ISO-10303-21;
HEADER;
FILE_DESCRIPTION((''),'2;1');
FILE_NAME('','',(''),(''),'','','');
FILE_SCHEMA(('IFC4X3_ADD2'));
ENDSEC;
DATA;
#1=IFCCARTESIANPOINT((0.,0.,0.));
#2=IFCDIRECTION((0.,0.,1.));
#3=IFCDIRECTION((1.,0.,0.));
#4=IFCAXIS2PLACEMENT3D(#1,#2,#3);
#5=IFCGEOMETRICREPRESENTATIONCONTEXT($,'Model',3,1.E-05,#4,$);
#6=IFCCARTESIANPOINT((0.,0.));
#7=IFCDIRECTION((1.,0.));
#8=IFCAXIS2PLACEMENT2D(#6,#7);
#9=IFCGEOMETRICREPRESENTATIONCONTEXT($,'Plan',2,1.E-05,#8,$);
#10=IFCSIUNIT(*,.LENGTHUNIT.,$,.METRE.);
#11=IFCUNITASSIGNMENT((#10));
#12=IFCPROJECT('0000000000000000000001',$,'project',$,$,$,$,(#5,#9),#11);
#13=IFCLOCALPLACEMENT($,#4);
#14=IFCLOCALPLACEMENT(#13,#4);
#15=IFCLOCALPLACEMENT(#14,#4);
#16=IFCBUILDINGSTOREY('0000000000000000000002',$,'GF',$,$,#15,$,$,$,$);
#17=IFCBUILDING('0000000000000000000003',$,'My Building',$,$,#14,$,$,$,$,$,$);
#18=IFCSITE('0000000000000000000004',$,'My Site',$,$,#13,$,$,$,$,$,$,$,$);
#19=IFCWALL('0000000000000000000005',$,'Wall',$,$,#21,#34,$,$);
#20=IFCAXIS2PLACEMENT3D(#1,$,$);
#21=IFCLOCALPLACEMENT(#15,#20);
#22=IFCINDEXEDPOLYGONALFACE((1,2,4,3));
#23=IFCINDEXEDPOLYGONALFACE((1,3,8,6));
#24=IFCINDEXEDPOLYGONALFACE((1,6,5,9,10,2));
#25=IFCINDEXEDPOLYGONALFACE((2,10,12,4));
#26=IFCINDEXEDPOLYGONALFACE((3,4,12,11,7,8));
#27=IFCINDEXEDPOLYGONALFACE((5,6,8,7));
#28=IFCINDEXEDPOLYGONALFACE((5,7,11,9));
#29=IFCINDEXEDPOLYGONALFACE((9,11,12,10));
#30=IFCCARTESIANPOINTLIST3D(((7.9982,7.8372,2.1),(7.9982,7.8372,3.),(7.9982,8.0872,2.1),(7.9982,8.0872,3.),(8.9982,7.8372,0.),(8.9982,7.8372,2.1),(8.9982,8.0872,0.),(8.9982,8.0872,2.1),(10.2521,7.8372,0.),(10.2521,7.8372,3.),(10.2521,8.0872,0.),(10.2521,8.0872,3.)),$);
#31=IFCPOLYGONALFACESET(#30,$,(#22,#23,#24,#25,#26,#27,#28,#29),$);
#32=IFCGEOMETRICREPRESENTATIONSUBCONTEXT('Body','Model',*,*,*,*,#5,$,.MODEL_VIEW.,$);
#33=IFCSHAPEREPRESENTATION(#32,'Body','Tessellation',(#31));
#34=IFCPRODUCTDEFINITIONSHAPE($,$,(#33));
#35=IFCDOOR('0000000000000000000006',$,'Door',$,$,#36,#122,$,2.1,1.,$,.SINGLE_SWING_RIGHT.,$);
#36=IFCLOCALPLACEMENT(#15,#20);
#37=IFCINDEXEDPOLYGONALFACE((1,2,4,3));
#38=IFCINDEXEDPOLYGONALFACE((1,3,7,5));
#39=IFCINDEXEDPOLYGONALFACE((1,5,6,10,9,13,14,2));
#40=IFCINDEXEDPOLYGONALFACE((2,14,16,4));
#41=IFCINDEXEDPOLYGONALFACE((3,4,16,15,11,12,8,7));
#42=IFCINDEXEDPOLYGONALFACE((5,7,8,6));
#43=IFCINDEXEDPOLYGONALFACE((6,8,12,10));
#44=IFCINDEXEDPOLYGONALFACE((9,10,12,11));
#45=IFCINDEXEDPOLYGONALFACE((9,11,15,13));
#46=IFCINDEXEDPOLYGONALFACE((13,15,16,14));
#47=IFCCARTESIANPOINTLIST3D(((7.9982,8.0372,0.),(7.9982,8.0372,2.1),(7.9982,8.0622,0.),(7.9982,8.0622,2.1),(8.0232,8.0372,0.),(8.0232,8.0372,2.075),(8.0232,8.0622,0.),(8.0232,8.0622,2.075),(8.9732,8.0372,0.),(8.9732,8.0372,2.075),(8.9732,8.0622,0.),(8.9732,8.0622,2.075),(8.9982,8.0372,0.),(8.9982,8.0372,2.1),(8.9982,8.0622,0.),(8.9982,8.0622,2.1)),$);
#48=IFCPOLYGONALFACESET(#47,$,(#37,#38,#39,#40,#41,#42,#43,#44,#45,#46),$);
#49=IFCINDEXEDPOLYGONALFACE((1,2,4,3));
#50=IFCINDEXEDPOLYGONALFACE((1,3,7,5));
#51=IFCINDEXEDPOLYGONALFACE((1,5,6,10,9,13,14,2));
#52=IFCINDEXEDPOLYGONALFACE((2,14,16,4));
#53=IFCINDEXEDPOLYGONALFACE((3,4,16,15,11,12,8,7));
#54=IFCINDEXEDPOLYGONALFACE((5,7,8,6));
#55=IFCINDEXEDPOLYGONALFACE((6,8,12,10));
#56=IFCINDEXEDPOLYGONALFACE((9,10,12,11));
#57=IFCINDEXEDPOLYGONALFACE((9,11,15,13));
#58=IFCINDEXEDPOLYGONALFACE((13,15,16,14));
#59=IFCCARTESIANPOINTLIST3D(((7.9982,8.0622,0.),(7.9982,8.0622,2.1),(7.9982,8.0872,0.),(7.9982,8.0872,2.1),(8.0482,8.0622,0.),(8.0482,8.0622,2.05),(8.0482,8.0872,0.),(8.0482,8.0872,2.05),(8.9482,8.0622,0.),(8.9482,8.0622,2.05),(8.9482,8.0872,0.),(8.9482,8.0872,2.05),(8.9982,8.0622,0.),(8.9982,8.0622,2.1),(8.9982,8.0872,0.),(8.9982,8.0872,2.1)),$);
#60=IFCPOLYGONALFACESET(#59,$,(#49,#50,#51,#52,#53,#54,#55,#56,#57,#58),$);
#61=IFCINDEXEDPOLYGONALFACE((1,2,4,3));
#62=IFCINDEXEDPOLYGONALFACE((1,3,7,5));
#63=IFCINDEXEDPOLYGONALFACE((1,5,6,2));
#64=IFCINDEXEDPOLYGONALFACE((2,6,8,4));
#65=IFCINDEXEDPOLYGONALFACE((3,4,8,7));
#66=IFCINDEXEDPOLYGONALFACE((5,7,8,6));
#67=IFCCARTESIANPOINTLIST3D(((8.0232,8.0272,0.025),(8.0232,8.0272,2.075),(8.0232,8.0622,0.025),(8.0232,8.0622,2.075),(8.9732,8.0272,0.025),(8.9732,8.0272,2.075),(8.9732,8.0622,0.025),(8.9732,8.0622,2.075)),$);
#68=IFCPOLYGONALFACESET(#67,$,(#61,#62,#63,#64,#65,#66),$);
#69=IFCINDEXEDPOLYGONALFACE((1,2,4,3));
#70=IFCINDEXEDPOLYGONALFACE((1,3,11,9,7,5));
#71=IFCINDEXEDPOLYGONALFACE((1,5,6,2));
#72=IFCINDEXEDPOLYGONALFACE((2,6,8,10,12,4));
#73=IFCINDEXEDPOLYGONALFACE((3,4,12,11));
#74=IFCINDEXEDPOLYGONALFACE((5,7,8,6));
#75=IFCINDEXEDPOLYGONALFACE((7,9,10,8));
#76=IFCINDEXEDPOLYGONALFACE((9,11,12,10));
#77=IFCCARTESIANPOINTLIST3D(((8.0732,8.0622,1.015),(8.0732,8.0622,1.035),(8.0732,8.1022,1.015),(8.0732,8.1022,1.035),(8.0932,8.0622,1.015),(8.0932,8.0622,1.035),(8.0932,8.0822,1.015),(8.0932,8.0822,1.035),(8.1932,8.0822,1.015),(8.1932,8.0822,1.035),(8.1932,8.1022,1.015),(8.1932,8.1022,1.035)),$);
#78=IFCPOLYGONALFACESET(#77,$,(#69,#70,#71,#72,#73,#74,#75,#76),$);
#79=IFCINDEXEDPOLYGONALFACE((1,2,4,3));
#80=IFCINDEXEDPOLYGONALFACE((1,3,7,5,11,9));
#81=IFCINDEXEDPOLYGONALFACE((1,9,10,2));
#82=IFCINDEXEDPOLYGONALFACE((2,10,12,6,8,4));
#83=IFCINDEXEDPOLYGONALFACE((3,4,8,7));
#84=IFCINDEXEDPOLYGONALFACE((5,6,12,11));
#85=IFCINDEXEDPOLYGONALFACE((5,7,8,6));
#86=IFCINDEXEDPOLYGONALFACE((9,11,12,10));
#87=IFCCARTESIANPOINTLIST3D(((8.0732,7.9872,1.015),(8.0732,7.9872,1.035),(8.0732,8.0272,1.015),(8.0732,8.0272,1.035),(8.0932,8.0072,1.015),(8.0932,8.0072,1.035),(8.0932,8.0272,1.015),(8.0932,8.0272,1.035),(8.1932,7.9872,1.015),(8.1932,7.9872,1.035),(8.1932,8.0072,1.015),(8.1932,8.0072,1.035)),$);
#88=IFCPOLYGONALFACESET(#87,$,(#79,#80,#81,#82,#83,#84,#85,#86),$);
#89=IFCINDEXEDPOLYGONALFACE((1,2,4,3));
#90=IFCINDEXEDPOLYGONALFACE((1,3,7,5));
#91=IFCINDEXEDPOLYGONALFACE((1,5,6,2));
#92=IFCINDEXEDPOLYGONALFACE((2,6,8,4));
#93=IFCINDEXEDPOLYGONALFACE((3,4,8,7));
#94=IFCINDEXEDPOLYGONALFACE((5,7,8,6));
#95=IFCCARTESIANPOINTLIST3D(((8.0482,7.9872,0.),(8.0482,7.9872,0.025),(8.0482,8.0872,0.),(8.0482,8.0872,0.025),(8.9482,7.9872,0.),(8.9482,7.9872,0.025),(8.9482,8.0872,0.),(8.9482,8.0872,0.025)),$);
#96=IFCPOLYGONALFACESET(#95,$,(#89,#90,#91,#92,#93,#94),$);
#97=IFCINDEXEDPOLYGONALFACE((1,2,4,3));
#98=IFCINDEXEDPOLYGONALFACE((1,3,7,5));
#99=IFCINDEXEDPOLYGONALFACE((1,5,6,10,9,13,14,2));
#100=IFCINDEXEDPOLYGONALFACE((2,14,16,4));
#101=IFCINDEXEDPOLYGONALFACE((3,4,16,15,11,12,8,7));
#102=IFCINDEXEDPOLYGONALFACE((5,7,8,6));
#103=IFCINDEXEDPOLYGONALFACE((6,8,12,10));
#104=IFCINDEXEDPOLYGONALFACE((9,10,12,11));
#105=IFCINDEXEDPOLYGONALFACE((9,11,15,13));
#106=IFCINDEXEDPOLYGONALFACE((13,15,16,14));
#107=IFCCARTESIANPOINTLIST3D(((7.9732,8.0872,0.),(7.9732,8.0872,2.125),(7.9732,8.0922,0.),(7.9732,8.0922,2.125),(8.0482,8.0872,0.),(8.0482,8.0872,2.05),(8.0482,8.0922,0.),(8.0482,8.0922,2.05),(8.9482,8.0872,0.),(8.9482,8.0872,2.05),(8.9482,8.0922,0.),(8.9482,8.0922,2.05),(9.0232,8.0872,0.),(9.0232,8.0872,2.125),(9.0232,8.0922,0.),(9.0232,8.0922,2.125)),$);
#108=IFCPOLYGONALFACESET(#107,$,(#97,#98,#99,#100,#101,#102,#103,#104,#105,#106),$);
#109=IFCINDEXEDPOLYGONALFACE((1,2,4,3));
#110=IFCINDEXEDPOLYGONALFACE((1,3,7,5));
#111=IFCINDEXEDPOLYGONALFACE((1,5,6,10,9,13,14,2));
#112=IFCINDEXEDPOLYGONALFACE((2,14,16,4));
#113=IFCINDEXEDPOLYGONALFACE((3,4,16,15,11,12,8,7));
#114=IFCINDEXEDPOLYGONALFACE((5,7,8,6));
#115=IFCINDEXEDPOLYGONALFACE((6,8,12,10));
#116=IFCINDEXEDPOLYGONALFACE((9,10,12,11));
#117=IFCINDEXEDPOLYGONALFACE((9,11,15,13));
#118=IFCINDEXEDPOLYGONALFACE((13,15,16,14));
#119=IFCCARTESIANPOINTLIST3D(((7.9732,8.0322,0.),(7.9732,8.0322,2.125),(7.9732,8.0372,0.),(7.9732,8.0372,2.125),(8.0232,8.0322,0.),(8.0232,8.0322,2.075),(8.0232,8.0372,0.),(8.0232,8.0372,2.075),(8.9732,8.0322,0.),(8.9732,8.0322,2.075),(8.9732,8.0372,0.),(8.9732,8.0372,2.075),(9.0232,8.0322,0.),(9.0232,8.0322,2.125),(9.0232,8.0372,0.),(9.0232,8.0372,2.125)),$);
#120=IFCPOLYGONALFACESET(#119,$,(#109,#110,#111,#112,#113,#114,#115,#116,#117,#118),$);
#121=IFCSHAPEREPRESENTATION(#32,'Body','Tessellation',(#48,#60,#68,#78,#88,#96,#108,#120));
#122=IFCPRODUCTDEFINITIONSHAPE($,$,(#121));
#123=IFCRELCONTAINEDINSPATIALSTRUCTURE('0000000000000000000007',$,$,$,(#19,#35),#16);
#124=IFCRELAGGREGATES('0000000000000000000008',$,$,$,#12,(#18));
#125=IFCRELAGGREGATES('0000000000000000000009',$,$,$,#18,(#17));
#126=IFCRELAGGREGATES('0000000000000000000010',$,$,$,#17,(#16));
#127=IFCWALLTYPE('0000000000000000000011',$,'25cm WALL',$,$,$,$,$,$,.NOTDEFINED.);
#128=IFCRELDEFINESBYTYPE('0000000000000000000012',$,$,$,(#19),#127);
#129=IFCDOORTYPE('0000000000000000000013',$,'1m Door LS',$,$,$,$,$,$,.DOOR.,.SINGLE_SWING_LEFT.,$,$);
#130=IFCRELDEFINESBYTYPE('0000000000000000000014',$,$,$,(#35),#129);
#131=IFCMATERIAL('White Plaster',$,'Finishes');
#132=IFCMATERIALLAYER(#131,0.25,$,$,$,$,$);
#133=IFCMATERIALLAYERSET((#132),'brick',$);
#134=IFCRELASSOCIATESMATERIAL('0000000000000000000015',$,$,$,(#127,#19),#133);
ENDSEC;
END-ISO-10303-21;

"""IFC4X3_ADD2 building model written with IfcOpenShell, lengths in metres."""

from ifc_helpers import new_model, entity, si_unit, frame, origin_with_axes, origin_2d_with_axis, place, context, subcontext, project, spatial, line, indexed_curve, outline, extrude, shape, source, transform, mapped, material, layer, layer_set, layer_usage, type_object, type_shapes, element, fill, save


model = new_model("IFC4X3_ADD2")

# Units and contexts
model_context = context("Model", 3, precision=1e-05, world=origin_with_axes())
plan_context = context("Plan", 2, precision=1e-05, world=origin_2d_with_axis())
body_context_1 = subcontext(model_context, "Body", "Model", "MODEL_VIEW")
body_context_2 = subcontext(plan_context, "Body", "Plan", "PLAN_VIEW")
ifc_project = project(units=[si_unit("LENGTHUNIT", "METRE")], contexts=[model_context, plan_context])

# Site, building, storey
site_placement = place(None, origin_with_axes())
site = spatial("IfcSite", under=ifc_project, at=site_placement, Name="My Site")
building_placement = place(site_placement, origin_with_axes())
building = spatial("IfcBuilding", under=site, at=building_placement, Name="My Building")
storey_placement = place(building_placement, origin_with_axes())
storey = spatial("IfcBuildingStorey", under=building, at=storey_placement, Name="GF")

# Shared definitions
ifc_material_1 = material(Name="White Plaster", Category="Finishes")

# Wall, opening, door
ifc_layer_1 = layer(ifc_material_1, 0.25)
ifc_layer_set_1 = layer_set([ifc_layer_1], Name="brick")
wall_type_1 = type_object("IfcWallType", Name="25cm WALL", PredefinedType="NOTDEFINED", material=ifc_layer_set_1)
shared_shape_1 = source(origin_with_axes(), body_context_1, "Body", "SweptSolid", [
    extrude(outline(indexed_curve([(0.0, 0.0), (1.0, 0.0), (1.0, 2.1), (0.0, 2.1)], segments=[line(1, 2, 3, 4, 1)])), frame((0.0, -0.6, 0.0), z_axis=(0.0, -1.0, 0.0), x_axis=(1.0, 0.0, 0.0)), (0.0, 0.0, -1.0), 1.2),
])
door_type_1 = type_object("IfcDoorType", Name="1m Door LS", OperationType="SINGLE_SWING_LEFT", PredefinedType="DOOR")
shared_shape_2 = source(origin_with_axes(), body_context_1, "Body", "SweptSolid", [
    extrude(outline(indexed_curve([(0.0, 0.0), (0.0, 2.1), (1.0, 2.1), (1.0, 0.0), (0.975, 0.0), (0.975, 2.075), (0.025, 2.075), (0.025, 0.0)], segments=[line(1, 2, 3, 4, 5, 6, 7, 8, 1)])), frame((0.0, 0.025, 0.0), z_axis=(0.0, -1.0, 0.0), x_axis=(1.0, 0.0, 0.0)), (0.0, 0.0, -1.0), 0.025),
    extrude(outline(indexed_curve([(0.0, 0.0), (0.0, 2.1), (1.0, 2.1), (1.0, 0.0), (0.95, 0.0), (0.95, 2.05), (0.05, 2.05), (0.05, 0.0)], segments=[line(1, 2, 3, 4, 5, 6, 7, 8, 1)])), frame((0.0, 0.0, 0.0), z_axis=(0.0, -1.0, 0.0), x_axis=(1.0, 0.0, 0.0)), (0.0, 0.0, -1.0), 0.025),
    extrude(outline(indexed_curve([(0.0, 0.0), (0.95, 0.0), (0.95, 0.035), (0.0, 0.035)], segments=[line(1, 2, 3, 4, 1)])), frame((0.025, 0.025, 0.025), z_axis=(0.0, 0.0, 1.0), x_axis=(1.0, 0.0, 0.0)), (0.0, 0.0, 1.0), 2.05),
    extrude(outline(indexed_curve([(0.0, 0.0), (0.0, -0.04), (-0.12, -0.04), (-0.12, -0.02), (-0.02, -0.02), (-0.02, 0.0)], segments=[line(1, 2, 3, 4, 5, 6, 1)])), frame((0.925, 0.025, 1.015), z_axis=(0.0, 0.0, 1.0), x_axis=(1.0, 0.0, 0.0)), (0.0, 0.0, 1.0), 0.02),
    extrude(outline(indexed_curve([(0.0, 0.0), (0.0, 0.04), (-0.12, 0.04), (-0.12, 0.02), (-0.02, 0.02), (-0.02, 0.0)], segments=[line(1, 2, 3, 4, 5, 6, 1)])), frame((0.925, 0.06, 1.015), z_axis=(0.0, 0.0, 1.0), x_axis=(1.0, 0.0, 0.0)), (0.0, 0.0, 1.0), 0.02),
    extrude(outline(indexed_curve([(0.0, 0.0), (0.9, 0.0), (0.9, 0.1), (0.0, 0.1)], segments=[line(1, 2, 3, 4, 1)])), frame((0.05, 0.0, 0.0), z_axis=(0.0, 0.0, 1.0), x_axis=(1.0, 0.0, 0.0)), (0.0, 0.0, 1.0), 0.025),
    extrude(outline(indexed_curve([(0.0, 0.0), (0.0, 2.125), (1.05, 2.125), (1.05, 0.0), (0.975, 0.0), (0.975, 2.05), (0.075, 2.05), (0.075, 0.0)], segments=[line(1, 2, 3, 4, 5, 6, 7, 8, 1)])), frame((-0.025, -0.005, 0.0), z_axis=(0.0, -1.0, 0.0), x_axis=(1.0, 0.0, 0.0)), (0.0, 0.0, -1.0), 0.005),
    extrude(outline(indexed_curve([(0.0, 0.0), (0.0, 2.125), (1.05, 2.125), (1.05, 0.0), (1.0, 0.0), (1.0, 2.075), (0.05, 2.075), (0.05, 0.0)], segments=[line(1, 2, 3, 4, 5, 6, 7, 8, 1)])), frame((-0.025, 0.05, 0.0), z_axis=(0.0, -1.0, 0.0), x_axis=(1.0, 0.0, 0.0)), (0.0, 0.0, -1.0), 0.005),
])
shared_shape_3 = source(origin_with_axes(), body_context_2, "Body", "Curve2D", [
    entity("IfcIndexedPolyCurve", entity("IfcCartesianPointList2D", [[0.0, 0.0], [0.0, 0.05], [0.025, 0.05], [0.025, 0.025], [0.05, 0.025], [0.05, 0.0]]), [entity("IfcLineIndex", [1, 2, 3, 4, 5, 6, 1])]),
    entity("IfcIndexedPolyCurve", entity("IfcCartesianPointList2D", [[1.0, 0.0], [1.0, 0.05], [0.975, 0.05], [0.975, 0.025], [0.95, 0.025], [0.95, 0.0]]), [entity("IfcLineIndex", [1, 2, 3, 4, 5, 6, 1])]),
    entity("IfcTrimmedCurve", entity("IfcEllipse", entity("IfcAxis2Placement2D", entity("IfcCartesianPoint", [0.06, 0.05]), entity("IfcDirection", [1.0, 0.0])), 0.915, 0.95), [entity("IfcCartesianPoint", [0.975, 0.05])], [entity("IfcCartesianPoint", [0.06, 1.0])], True, "CARTESIAN"),
    entity("IfcIndexedPolyCurve", entity("IfcCartesianPointList2D", [[0.025, 0.05], [0.06, 0.05], [0.06, 1.0], [0.025, 1.0]]), [entity("IfcLineIndex", [1, 2, 3, 4, 1])]),
])
type_shapes(door_type_1, [shared_shape_2, shared_shape_3])
ifc_layer_usage_1 = layer_usage(ifc_layer_set_1, "AXIS2", "POSITIVE", 0.0)
wall_1_placement = place(storey_placement, frame((7.9982, 7.8372, 0.0), z_axis=(0.0, 0.0, 1.0), x_axis=(1.0, 0.0, 0.0)))
wall_1 = element("IfcWall", 1, at=wall_1_placement, inside=storey, type_object=wall_type_1, material=ifc_layer_usage_1, Name="Wall", context=body_context_1, shape_type="SweptSolid", body=[
    extrude(outline(indexed_curve([(0.0, 0.0), (0.0, 0.25), (2.2539, 0.25), (2.2539, 0.0)], segments=[line(1, 2, 3, 4, 1)])), origin_with_axes(), (0.0, 0.0, 1.0), 3.0),
])
opening_1_placement = place(wall_1_placement, frame((1.0, 0.25, 0.0), z_axis=(0.0, 0.0, 1.0), x_axis=(-1.0, 0.0, 0.0)))
opening_1 = element("IfcOpeningElement", 2, at=opening_1_placement, cuts=wall_1, PredefinedType="OPENING", context=body_context_1, shape_type="MappedRepresentation", body=[
    mapped(shared_shape_1, transform((0.0, 0.0, 0.0), x_axis=(1.0, 0.0, 0.0), y_axis=(0.0, 1.0, 0.0), z_axis=(0.0, 0.0, 1.0), scale=1.0)),
])
door_1_placement = place(opening_1_placement, frame((0.0, 0.0, 0.0), z_axis=(0.0, 0.0, 1.0), x_axis=(1.0, 0.0, 0.0)))
door_1 = element("IfcDoor", 3, at=door_1_placement, inside=storey, type_object=door_type_1, Name="Door", OperationType="SINGLE_SWING_RIGHT", OverallHeight=2.1, OverallWidth=1.0, shapes=[
    shape(body_context_1, "Body", "MappedRepresentation", [mapped(shared_shape_2, transform((0.0, 0.0, 0.0), x_axis=(1.0, 0.0, 0.0), y_axis=(0.0, 1.0, 0.0), z_axis=(0.0, 0.0, 1.0), scale=1.0))]),
    shape(body_context_2, "Body", "MappedRepresentation", [mapped(shared_shape_3, transform((0.0, 0.0, 0.0), x_axis=(1.0, 0.0, 0.0), y_axis=(0.0, 1.0, 0.0), z_axis=(0.0, 0.0, 1.0), scale=1.0))]),
])
fill(opening_1, door_1)

save(model, "model.ifc")
